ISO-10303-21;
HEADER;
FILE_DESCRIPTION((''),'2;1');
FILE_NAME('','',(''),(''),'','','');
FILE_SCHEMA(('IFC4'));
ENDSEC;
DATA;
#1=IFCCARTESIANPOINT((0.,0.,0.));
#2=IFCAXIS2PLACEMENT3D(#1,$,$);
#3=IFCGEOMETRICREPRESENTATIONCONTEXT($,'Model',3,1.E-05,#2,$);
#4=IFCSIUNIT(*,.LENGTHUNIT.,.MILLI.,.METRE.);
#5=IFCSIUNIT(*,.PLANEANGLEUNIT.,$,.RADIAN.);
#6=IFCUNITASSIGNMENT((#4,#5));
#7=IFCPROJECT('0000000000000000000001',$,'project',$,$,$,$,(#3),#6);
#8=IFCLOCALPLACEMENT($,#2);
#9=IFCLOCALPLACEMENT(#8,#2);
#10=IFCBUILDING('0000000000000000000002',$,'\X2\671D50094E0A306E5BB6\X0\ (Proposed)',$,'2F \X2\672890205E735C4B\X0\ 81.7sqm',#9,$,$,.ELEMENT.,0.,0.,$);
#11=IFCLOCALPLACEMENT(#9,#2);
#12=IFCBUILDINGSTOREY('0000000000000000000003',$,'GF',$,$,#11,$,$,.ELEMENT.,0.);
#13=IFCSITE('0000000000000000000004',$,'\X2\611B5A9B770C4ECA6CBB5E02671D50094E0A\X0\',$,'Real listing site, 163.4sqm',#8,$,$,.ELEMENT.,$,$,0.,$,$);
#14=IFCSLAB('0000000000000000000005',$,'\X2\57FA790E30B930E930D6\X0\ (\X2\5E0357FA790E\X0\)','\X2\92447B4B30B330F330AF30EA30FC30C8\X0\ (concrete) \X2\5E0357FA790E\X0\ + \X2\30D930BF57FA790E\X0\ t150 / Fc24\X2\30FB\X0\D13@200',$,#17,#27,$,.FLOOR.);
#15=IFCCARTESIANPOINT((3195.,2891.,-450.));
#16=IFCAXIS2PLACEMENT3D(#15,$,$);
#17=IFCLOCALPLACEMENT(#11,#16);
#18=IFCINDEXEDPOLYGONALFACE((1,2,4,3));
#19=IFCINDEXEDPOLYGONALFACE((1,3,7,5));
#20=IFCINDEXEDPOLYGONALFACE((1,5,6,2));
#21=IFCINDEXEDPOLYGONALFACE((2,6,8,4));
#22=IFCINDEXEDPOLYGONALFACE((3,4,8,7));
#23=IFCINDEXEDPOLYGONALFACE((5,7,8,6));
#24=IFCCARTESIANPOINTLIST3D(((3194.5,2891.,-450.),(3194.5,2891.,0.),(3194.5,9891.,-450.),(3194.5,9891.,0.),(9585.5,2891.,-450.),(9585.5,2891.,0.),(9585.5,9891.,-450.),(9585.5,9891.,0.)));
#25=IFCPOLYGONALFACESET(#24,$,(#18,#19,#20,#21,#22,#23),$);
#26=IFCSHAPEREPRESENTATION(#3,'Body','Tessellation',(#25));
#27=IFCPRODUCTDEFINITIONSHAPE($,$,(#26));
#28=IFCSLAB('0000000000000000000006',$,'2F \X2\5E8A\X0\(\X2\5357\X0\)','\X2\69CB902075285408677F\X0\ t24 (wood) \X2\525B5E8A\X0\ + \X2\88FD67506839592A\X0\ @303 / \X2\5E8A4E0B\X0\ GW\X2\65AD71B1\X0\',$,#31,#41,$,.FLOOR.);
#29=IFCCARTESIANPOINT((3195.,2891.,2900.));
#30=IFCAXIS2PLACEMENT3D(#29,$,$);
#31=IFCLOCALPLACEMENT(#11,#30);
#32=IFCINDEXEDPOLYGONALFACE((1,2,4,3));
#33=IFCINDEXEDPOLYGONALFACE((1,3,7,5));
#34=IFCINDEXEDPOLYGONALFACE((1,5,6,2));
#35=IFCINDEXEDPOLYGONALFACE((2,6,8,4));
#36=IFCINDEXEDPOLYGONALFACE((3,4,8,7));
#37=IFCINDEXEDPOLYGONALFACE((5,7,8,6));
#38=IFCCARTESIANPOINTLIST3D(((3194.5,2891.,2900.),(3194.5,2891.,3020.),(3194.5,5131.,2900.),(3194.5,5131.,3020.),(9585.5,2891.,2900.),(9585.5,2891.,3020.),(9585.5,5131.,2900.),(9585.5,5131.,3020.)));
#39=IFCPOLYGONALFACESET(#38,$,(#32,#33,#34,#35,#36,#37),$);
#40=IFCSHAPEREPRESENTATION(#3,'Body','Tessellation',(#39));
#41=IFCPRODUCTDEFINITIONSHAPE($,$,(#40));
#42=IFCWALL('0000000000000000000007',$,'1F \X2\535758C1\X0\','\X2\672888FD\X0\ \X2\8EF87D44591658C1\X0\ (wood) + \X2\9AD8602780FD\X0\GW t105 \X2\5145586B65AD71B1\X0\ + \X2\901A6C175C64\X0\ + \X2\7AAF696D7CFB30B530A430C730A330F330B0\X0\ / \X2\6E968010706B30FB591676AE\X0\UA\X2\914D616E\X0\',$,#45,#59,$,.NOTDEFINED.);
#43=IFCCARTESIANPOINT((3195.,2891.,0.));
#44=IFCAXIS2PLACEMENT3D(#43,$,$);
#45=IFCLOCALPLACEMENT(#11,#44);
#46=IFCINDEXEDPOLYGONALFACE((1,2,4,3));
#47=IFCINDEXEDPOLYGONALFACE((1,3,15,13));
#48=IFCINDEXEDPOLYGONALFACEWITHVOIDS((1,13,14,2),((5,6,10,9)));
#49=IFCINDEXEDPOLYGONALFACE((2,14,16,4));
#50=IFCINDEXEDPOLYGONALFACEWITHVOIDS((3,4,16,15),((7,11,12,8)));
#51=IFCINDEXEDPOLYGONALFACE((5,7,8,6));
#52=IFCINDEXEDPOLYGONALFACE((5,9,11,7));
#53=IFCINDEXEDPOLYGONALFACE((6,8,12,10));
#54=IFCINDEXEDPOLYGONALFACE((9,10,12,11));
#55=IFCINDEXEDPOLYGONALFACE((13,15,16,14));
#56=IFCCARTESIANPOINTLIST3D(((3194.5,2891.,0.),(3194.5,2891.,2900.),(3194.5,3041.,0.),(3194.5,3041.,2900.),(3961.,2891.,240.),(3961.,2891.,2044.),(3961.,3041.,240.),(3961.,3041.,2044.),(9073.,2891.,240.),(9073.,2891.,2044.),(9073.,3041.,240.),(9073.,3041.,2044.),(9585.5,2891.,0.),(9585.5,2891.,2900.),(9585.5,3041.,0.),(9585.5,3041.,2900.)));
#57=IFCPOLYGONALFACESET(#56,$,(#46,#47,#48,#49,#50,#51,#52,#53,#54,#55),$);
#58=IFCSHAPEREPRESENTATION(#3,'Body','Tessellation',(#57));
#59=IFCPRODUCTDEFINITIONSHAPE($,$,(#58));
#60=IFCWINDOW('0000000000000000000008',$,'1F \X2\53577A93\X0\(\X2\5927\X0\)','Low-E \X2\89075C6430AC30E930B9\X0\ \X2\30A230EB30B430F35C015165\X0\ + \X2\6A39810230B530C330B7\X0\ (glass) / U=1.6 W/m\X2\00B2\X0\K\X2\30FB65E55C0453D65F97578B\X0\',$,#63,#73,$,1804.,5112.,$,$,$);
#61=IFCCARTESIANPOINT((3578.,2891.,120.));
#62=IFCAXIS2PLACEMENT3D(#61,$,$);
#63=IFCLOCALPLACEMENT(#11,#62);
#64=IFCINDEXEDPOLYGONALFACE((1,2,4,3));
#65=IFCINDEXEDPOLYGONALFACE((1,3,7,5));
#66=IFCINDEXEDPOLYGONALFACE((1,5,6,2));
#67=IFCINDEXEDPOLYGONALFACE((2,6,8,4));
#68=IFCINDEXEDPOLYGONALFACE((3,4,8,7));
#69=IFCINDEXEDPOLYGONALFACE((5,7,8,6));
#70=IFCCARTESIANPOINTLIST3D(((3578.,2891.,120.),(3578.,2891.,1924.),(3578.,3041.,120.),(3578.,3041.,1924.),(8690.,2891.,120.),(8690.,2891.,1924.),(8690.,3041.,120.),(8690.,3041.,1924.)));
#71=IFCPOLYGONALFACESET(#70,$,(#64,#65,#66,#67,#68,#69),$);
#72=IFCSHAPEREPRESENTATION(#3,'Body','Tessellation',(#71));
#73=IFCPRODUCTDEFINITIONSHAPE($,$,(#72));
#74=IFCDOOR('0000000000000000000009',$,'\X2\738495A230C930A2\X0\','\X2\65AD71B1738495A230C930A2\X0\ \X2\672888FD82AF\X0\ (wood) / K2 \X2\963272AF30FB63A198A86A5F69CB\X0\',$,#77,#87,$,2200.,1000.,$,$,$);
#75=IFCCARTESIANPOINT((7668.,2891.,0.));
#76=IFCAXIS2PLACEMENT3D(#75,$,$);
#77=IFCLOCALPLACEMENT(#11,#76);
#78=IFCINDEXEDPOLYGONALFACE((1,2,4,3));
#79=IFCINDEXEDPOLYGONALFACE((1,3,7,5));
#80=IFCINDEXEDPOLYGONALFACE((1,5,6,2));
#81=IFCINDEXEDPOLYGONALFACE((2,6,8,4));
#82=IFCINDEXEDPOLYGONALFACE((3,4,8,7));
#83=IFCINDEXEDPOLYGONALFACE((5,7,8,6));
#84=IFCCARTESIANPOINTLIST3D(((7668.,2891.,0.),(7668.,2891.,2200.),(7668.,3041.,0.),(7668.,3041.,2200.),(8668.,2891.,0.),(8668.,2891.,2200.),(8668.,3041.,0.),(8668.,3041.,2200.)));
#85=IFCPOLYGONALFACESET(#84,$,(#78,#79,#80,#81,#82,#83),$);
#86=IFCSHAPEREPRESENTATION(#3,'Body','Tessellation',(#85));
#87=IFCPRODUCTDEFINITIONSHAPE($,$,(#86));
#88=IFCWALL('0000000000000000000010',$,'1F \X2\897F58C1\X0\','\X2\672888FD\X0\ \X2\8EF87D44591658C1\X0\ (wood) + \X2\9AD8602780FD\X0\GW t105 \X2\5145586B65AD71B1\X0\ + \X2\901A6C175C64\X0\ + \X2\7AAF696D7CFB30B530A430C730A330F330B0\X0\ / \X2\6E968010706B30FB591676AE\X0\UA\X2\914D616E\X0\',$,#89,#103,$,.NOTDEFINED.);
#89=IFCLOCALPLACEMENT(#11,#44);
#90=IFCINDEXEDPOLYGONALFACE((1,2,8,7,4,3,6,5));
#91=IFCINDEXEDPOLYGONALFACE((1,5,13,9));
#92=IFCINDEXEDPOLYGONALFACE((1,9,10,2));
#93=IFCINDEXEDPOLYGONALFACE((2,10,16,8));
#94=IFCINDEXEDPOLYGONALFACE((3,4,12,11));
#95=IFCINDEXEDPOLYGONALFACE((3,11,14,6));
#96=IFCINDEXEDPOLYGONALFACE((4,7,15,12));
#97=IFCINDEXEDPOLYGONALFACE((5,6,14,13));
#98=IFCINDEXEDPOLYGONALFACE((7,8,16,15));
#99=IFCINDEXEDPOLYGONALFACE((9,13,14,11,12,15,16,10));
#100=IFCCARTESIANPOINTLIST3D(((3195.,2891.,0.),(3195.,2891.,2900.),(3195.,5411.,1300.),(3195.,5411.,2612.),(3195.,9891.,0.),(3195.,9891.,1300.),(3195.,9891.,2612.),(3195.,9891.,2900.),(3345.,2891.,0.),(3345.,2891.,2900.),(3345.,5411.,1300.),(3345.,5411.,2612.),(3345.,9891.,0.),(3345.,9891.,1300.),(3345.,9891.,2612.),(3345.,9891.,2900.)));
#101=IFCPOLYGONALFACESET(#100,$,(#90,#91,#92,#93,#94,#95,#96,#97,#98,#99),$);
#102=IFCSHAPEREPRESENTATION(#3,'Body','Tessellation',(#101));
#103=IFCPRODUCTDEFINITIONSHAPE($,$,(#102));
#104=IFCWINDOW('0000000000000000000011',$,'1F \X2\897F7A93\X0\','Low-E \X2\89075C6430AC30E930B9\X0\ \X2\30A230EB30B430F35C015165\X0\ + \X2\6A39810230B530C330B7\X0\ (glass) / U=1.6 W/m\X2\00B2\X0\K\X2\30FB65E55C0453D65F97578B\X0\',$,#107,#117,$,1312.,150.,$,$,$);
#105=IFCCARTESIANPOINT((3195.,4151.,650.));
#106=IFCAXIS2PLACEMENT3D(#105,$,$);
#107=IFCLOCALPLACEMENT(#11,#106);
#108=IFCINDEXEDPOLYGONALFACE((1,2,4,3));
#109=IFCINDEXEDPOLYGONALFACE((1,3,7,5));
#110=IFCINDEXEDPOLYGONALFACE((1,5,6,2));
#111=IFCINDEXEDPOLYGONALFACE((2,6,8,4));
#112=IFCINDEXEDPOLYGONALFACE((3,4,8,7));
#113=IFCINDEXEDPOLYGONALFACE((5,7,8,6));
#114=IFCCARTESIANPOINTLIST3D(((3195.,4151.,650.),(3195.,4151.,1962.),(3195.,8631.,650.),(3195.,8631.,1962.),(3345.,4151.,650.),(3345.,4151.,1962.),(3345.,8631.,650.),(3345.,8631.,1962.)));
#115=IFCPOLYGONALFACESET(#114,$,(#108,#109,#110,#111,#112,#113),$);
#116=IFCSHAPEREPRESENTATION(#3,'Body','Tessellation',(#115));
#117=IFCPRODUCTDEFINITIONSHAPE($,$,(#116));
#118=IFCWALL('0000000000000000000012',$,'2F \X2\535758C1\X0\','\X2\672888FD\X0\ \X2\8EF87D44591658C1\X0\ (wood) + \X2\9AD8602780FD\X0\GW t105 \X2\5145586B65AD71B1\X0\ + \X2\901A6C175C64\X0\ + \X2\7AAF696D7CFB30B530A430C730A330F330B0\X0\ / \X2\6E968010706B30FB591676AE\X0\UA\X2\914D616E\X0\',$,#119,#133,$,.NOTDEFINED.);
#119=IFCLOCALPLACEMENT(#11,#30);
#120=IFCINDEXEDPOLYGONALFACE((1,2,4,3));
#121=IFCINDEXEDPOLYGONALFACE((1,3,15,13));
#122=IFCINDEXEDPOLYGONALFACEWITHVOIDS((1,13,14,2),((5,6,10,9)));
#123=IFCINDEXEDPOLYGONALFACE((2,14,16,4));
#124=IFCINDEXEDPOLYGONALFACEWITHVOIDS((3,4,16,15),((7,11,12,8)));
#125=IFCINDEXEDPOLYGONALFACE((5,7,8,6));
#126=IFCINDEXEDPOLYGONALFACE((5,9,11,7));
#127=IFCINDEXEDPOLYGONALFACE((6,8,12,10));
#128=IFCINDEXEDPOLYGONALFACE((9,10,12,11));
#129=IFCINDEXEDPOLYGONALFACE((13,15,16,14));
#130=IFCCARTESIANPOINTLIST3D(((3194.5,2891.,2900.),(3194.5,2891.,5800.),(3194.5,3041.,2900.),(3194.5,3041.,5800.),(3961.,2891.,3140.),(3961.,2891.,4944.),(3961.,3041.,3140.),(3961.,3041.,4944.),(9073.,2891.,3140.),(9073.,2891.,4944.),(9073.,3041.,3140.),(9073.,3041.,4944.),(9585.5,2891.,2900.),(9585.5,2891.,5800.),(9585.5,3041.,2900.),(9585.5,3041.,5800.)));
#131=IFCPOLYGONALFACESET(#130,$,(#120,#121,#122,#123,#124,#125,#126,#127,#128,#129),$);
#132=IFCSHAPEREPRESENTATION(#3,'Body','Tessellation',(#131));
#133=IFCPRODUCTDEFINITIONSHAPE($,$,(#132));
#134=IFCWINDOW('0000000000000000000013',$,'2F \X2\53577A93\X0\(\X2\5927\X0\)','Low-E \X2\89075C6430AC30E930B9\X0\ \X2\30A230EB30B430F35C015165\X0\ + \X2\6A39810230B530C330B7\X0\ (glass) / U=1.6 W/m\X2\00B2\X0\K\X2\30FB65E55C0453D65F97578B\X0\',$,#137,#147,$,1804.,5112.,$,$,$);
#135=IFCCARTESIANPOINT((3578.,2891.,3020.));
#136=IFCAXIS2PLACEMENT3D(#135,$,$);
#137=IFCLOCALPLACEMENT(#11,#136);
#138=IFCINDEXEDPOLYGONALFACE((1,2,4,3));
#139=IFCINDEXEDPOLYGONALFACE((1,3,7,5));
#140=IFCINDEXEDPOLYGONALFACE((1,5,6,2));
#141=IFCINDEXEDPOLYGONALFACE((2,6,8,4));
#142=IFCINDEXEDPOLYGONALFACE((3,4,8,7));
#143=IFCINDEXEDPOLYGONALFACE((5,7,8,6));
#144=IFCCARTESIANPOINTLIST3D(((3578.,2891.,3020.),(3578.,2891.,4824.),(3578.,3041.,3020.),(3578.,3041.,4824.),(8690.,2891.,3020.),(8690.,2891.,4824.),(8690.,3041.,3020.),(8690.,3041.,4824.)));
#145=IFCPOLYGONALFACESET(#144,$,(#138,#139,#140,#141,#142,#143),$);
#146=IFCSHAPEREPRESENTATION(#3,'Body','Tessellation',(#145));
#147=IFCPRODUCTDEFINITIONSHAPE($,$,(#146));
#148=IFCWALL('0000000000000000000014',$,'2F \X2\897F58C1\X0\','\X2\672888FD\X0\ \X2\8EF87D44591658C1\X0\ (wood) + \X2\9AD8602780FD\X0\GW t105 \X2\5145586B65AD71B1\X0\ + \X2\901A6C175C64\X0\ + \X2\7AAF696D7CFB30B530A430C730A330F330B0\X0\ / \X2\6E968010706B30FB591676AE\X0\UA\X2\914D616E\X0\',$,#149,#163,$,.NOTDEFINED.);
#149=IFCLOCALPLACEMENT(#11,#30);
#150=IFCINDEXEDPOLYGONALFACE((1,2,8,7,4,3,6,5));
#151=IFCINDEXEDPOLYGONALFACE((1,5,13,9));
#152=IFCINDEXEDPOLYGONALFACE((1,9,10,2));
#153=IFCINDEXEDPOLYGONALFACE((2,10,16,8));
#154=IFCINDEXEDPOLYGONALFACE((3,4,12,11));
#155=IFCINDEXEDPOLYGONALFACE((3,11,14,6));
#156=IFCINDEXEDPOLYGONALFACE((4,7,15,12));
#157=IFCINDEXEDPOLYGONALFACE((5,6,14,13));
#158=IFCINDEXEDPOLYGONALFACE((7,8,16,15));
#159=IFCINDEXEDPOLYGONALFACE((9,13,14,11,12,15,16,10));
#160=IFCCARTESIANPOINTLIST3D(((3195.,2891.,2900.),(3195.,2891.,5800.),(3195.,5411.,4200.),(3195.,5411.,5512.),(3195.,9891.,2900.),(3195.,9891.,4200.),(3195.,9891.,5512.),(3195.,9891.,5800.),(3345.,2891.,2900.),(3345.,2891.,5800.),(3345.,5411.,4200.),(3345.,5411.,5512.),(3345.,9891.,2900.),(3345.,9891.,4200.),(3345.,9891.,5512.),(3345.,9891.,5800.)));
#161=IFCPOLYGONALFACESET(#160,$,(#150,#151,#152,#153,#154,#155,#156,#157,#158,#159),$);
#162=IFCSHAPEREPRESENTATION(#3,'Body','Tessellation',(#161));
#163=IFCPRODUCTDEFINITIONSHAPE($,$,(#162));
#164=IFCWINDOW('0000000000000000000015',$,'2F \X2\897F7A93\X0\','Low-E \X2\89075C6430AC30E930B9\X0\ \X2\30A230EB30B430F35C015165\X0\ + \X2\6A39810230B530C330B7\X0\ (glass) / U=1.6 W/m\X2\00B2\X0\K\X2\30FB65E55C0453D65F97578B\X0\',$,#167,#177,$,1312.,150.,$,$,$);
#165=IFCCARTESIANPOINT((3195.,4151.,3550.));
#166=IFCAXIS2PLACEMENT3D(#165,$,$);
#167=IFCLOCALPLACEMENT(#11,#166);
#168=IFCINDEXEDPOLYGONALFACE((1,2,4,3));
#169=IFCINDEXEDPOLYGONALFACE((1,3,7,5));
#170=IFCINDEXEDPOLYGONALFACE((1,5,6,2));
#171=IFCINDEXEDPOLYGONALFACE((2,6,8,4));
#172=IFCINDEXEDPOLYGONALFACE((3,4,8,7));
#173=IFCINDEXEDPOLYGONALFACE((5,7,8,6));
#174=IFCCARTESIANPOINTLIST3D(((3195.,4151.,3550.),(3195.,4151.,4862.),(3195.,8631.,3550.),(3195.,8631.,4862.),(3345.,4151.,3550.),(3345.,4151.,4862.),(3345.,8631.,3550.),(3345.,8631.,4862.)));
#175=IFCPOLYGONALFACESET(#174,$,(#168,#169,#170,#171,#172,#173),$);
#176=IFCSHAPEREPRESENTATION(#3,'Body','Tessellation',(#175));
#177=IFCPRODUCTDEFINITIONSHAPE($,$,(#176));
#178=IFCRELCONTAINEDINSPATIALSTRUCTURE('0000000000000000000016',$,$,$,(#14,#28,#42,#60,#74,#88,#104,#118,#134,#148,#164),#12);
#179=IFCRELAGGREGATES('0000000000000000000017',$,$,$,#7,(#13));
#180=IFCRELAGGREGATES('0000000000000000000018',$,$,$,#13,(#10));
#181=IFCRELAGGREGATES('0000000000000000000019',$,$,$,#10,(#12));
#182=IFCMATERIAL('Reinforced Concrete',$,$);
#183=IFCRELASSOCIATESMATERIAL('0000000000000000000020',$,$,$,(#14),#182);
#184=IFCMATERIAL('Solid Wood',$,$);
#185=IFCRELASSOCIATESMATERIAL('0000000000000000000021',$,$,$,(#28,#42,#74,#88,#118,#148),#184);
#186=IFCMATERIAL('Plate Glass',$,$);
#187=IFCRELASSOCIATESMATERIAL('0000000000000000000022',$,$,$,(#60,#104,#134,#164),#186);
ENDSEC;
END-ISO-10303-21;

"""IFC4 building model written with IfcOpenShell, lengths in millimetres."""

from ifc_helpers import new_model, si_unit, frame, frame_2d, origin, place, context, project, spatial, rectangle, extrude, material, element, fill, save


model = new_model("IFC4")

# Units and contexts
model_context = context("Model", 3, precision=1e-05, world=origin())
ifc_project = project(units=[si_unit("LENGTHUNIT", "METRE", prefix="MILLI"), si_unit("PLANEANGLEUNIT", "RADIAN")], contexts=[model_context])

# Site, building, storey
site_placement = place(None, origin())
site = spatial("IfcSite", under=ifc_project, at=site_placement, Name="愛媛県今治市朝倉上", ObjectType="Real listing site, 163.4sqm", CompositionType="ELEMENT", RefElevation=0.0)
building_placement = place(site_placement, origin())
building = spatial("IfcBuilding", under=site, at=building_placement, Name="朝倉上の家 (Proposed)", ObjectType="2F 木造平屋 81.7sqm", CompositionType="ELEMENT", ElevationOfRefHeight=0.0, ElevationOfTerrain=0.0)
storey_placement = place(building_placement, origin())
storey = spatial("IfcBuildingStorey", under=building, at=storey_placement, Name="GF", CompositionType="ELEMENT", Elevation=0.0)

# Slabs
ifc_material_1 = material(Name="Reinforced Concrete")
slab_1_placement = place(storey_placement, frame((3195.0, 2891.0, -450.0)))
element("IfcSlab", 1, at=slab_1_placement, inside=storey, material=ifc_material_1, Name="基礎スラブ (布基礎)", Description="鉄筋コンクリート (concrete) 布基礎 + ベタ基礎 t150 / Fc24・D13@200", PredefinedType="FLOOR", context=model_context, shape_type="SweptSolid", body=[
    extrude(rectangle(XDim=6391.0, YDim=7000.0, at=frame_2d((3195.0, 3500.0))), frame((3195.0, 2891.0, -450.0)), (0.0, 0.0, 1.0), 450.0),
])
ifc_material_2 = material(Name="Solid Wood")
slab_2_placement = place(storey_placement, frame((3195.0, 2891.0, 2900.0)))
element("IfcSlab", 2, at=slab_2_placement, inside=storey, material=ifc_material_2, Name="2F 床(南)", Description="構造用合板 t24 (wood) 剛床 + 製材根太 @303 / 床下 GW断熱", PredefinedType="FLOOR", context=model_context, shape_type="SweptSolid", body=[
    extrude(rectangle(XDim=6391.0, YDim=2240.0, at=frame_2d((3195.0, 1120.0))), frame((3195.0, 2891.0, 2900.0)), (0.0, 0.0, 1.0), 120.0),
])

# Wall, openings, window, door
wall_1_placement = place(storey_placement, frame((3195.0, 2891.0, 0.0)))
wall_1 = element("IfcWall", 3, at=wall_1_placement, inside=storey, material=ifc_material_2, Name="1F 南壁", Description="木製 軸組外壁 (wood) + 高性能GW t105 充填断熱 + 通気層 + 窯業系サイディング / 準耐火・外皮UA配慮", PredefinedType="NOTDEFINED", context=model_context, shape_type="SweptSolid", body=[
    extrude(rectangle(XDim=6391.0, YDim=150.0, at=frame_2d((3195.0, 75.0))), frame((3195.0, 2891.0, 0.0)), (0.0, 0.0, 1.0), 2900.0),
])
opening_1_placement = place(storey_placement, frame((3578.0, 2891.0, 120.0)))
opening_1 = element("IfcOpeningElement", 4, at=opening_1_placement, cuts=wall_1, PredefinedType="NOTDEFINED", context=model_context, shape_type="SweptSolid", body=[
    extrude(rectangle(XDim=5112.0, YDim=150.0, at=frame_2d((2556.0, 75.0))), frame((3578.0, 2891.0, 120.0)), (0.0, 0.0, 1.0), 1804.0),
])
opening_2_placement = place(storey_placement, frame((7668.0, 2891.0, 0.0)))
opening_2 = element("IfcOpeningElement", 5, at=opening_2_placement, cuts=wall_1, PredefinedType="NOTDEFINED", context=model_context, shape_type="SweptSolid", body=[
    extrude(rectangle(XDim=1000.0, YDim=150.0, at=frame_2d((500.0, 75.0))), frame((7668.0, 2891.0, 0.0)), (0.0, 0.0, 1.0), 2200.0),
])
ifc_material_3 = material(Name="Plate Glass")
window_1_placement = place(storey_placement, frame((3578.0, 2891.0, 120.0)))
window_1 = element("IfcWindow", 6, at=window_1_placement, inside=storey, material=ifc_material_3, Name="1F 南窓(大)", Description="Low-E 複層ガラス アルゴン封入 + 樹脂サッシ (glass) / U=1.6 W/m²K・日射取得型", OverallHeight=1804.0, OverallWidth=5112.0, context=model_context, shape_type="SweptSolid", body=[
    extrude(rectangle(XDim=5112.0, YDim=150.0, at=frame_2d((2556.0, 75.0))), frame((3578.0, 2891.0, 120.0)), (0.0, 0.0, 1.0), 1804.0),
])
fill(opening_1, window_1)
door_placement = place(storey_placement, frame((7668.0, 2891.0, 0.0)))
door = element("IfcDoor", 7, at=door_placement, inside=storey, material=ifc_material_2, Name="玄関ドア", Description="断熱玄関ドア 木製芯 (wood) / K2 防犯・採風機構", OverallHeight=2200.0, OverallWidth=1000.0, context=model_context, shape_type="SweptSolid", body=[
    extrude(rectangle(XDim=1000.0, YDim=150.0, at=frame_2d((500.0, 75.0))), frame((7668.0, 2891.0, 0.0)), (0.0, 0.0, 1.0), 2200.0),
])
fill(opening_2, door)

# Walls, openings, windows
wall_2_placement = place(storey_placement, frame((3195.0, 2891.0, 0.0)))
wall_2 = element("IfcWall", 8, at=wall_2_placement, inside=storey, material=ifc_material_2, Name="1F 西壁", Description="木製 軸組外壁 (wood) + 高性能GW t105 充填断熱 + 通気層 + 窯業系サイディング / 準耐火・外皮UA配慮", PredefinedType="NOTDEFINED", context=model_context, shape_type="SweptSolid", body=[
    extrude(rectangle(XDim=150.0, YDim=7000.0, at=frame_2d((75.0, 3500.0))), frame((3195.0, 2891.0, 0.0)), (0.0, 0.0, 1.0), 2900.0),
])
opening_3_placement = place(storey_placement, frame((3195.0, 4151.0, 650.0)))
opening_3 = element("IfcOpeningElement", 9, at=opening_3_placement, cuts=wall_2, PredefinedType="NOTDEFINED", context=model_context, shape_type="SweptSolid", body=[
    extrude(rectangle(XDim=150.0, YDim=4480.0, at=frame_2d((75.0, 2240.0))), frame((3195.0, 4151.0, 650.0)), (0.0, 0.0, 1.0), 1312.0),
])
window_2_placement = place(storey_placement, frame((3195.0, 4151.0, 650.0)))
window_2 = element("IfcWindow", 10, at=window_2_placement, inside=storey, material=ifc_material_3, Name="1F 西窓", Description="Low-E 複層ガラス アルゴン封入 + 樹脂サッシ (glass) / U=1.6 W/m²K・日射取得型", OverallHeight=1312.0, OverallWidth=150.0, context=model_context, shape_type="SweptSolid", body=[
    extrude(rectangle(XDim=150.0, YDim=4480.0, at=frame_2d((75.0, 2240.0))), frame((3195.0, 4151.0, 650.0)), (0.0, 0.0, 1.0), 1312.0),
])
fill(opening_3, window_2)
wall_3_placement = place(storey_placement, frame((3195.0, 2891.0, 2900.0)))
wall_3 = element("IfcWall", 11, at=wall_3_placement, inside=storey, material=ifc_material_2, Name="2F 南壁", Description="木製 軸組外壁 (wood) + 高性能GW t105 充填断熱 + 通気層 + 窯業系サイディング / 準耐火・外皮UA配慮", PredefinedType="NOTDEFINED", context=model_context, shape_type="SweptSolid", body=[
    extrude(rectangle(XDim=6391.0, YDim=150.0, at=frame_2d((3195.0, 75.0))), frame((3195.0, 2891.0, 2900.0)), (0.0, 0.0, 1.0), 2900.0),
])
opening_4_placement = place(storey_placement, frame((3578.0, 2891.0, 3020.0)))
opening_4 = element("IfcOpeningElement", 12, at=opening_4_placement, cuts=wall_3, PredefinedType="NOTDEFINED", context=model_context, shape_type="SweptSolid", body=[
    extrude(rectangle(XDim=5112.0, YDim=150.0, at=frame_2d((2556.0, 75.0))), frame((3578.0, 2891.0, 3020.0)), (0.0, 0.0, 1.0), 1804.0),
])
window_3_placement = place(storey_placement, frame((3578.0, 2891.0, 3020.0)))
window_3 = element("IfcWindow", 13, at=window_3_placement, inside=storey, material=ifc_material_3, Name="2F 南窓(大)", Description="Low-E 複層ガラス アルゴン封入 + 樹脂サッシ (glass) / U=1.6 W/m²K・日射取得型", OverallHeight=1804.0, OverallWidth=5112.0, context=model_context, shape_type="SweptSolid", body=[
    extrude(rectangle(XDim=5112.0, YDim=150.0, at=frame_2d((2556.0, 75.0))), frame((3578.0, 2891.0, 3020.0)), (0.0, 0.0, 1.0), 1804.0),
])
fill(opening_4, window_3)
wall_4_placement = place(storey_placement, frame((3195.0, 2891.0, 2900.0)))
wall_4 = element("IfcWall", 14, at=wall_4_placement, inside=storey, material=ifc_material_2, Name="2F 西壁", Description="木製 軸組外壁 (wood) + 高性能GW t105 充填断熱 + 通気層 + 窯業系サイディング / 準耐火・外皮UA配慮", PredefinedType="NOTDEFINED", context=model_context, shape_type="SweptSolid", body=[
    extrude(rectangle(XDim=150.0, YDim=7000.0, at=frame_2d((75.0, 3500.0))), frame((3195.0, 2891.0, 2900.0)), (0.0, 0.0, 1.0), 2900.0),
])
opening_5_placement = place(storey_placement, frame((3195.0, 4151.0, 3550.0)))
opening_5 = element("IfcOpeningElement", 15, at=opening_5_placement, cuts=wall_4, PredefinedType="NOTDEFINED", context=model_context, shape_type="SweptSolid", body=[
    extrude(rectangle(XDim=150.0, YDim=4480.0, at=frame_2d((75.0, 2240.0))), frame((3195.0, 4151.0, 3550.0)), (0.0, 0.0, 1.0), 1312.0),
])
window_4_placement = place(storey_placement, frame((3195.0, 4151.0, 3550.0)))
window_4 = element("IfcWindow", 16, at=window_4_placement, inside=storey, material=ifc_material_3, Name="2F 西窓", Description="Low-E 複層ガラス アルゴン封入 + 樹脂サッシ (glass) / U=1.6 W/m²K・日射取得型", OverallHeight=1312.0, OverallWidth=150.0, context=model_context, shape_type="SweptSolid", body=[
    extrude(rectangle(XDim=150.0, YDim=4480.0, at=frame_2d((75.0, 2240.0))), frame((3195.0, 4151.0, 3550.0)), (0.0, 0.0, 1.0), 1312.0),
])
fill(opening_5, window_4)

save(model, "model.ifc")
